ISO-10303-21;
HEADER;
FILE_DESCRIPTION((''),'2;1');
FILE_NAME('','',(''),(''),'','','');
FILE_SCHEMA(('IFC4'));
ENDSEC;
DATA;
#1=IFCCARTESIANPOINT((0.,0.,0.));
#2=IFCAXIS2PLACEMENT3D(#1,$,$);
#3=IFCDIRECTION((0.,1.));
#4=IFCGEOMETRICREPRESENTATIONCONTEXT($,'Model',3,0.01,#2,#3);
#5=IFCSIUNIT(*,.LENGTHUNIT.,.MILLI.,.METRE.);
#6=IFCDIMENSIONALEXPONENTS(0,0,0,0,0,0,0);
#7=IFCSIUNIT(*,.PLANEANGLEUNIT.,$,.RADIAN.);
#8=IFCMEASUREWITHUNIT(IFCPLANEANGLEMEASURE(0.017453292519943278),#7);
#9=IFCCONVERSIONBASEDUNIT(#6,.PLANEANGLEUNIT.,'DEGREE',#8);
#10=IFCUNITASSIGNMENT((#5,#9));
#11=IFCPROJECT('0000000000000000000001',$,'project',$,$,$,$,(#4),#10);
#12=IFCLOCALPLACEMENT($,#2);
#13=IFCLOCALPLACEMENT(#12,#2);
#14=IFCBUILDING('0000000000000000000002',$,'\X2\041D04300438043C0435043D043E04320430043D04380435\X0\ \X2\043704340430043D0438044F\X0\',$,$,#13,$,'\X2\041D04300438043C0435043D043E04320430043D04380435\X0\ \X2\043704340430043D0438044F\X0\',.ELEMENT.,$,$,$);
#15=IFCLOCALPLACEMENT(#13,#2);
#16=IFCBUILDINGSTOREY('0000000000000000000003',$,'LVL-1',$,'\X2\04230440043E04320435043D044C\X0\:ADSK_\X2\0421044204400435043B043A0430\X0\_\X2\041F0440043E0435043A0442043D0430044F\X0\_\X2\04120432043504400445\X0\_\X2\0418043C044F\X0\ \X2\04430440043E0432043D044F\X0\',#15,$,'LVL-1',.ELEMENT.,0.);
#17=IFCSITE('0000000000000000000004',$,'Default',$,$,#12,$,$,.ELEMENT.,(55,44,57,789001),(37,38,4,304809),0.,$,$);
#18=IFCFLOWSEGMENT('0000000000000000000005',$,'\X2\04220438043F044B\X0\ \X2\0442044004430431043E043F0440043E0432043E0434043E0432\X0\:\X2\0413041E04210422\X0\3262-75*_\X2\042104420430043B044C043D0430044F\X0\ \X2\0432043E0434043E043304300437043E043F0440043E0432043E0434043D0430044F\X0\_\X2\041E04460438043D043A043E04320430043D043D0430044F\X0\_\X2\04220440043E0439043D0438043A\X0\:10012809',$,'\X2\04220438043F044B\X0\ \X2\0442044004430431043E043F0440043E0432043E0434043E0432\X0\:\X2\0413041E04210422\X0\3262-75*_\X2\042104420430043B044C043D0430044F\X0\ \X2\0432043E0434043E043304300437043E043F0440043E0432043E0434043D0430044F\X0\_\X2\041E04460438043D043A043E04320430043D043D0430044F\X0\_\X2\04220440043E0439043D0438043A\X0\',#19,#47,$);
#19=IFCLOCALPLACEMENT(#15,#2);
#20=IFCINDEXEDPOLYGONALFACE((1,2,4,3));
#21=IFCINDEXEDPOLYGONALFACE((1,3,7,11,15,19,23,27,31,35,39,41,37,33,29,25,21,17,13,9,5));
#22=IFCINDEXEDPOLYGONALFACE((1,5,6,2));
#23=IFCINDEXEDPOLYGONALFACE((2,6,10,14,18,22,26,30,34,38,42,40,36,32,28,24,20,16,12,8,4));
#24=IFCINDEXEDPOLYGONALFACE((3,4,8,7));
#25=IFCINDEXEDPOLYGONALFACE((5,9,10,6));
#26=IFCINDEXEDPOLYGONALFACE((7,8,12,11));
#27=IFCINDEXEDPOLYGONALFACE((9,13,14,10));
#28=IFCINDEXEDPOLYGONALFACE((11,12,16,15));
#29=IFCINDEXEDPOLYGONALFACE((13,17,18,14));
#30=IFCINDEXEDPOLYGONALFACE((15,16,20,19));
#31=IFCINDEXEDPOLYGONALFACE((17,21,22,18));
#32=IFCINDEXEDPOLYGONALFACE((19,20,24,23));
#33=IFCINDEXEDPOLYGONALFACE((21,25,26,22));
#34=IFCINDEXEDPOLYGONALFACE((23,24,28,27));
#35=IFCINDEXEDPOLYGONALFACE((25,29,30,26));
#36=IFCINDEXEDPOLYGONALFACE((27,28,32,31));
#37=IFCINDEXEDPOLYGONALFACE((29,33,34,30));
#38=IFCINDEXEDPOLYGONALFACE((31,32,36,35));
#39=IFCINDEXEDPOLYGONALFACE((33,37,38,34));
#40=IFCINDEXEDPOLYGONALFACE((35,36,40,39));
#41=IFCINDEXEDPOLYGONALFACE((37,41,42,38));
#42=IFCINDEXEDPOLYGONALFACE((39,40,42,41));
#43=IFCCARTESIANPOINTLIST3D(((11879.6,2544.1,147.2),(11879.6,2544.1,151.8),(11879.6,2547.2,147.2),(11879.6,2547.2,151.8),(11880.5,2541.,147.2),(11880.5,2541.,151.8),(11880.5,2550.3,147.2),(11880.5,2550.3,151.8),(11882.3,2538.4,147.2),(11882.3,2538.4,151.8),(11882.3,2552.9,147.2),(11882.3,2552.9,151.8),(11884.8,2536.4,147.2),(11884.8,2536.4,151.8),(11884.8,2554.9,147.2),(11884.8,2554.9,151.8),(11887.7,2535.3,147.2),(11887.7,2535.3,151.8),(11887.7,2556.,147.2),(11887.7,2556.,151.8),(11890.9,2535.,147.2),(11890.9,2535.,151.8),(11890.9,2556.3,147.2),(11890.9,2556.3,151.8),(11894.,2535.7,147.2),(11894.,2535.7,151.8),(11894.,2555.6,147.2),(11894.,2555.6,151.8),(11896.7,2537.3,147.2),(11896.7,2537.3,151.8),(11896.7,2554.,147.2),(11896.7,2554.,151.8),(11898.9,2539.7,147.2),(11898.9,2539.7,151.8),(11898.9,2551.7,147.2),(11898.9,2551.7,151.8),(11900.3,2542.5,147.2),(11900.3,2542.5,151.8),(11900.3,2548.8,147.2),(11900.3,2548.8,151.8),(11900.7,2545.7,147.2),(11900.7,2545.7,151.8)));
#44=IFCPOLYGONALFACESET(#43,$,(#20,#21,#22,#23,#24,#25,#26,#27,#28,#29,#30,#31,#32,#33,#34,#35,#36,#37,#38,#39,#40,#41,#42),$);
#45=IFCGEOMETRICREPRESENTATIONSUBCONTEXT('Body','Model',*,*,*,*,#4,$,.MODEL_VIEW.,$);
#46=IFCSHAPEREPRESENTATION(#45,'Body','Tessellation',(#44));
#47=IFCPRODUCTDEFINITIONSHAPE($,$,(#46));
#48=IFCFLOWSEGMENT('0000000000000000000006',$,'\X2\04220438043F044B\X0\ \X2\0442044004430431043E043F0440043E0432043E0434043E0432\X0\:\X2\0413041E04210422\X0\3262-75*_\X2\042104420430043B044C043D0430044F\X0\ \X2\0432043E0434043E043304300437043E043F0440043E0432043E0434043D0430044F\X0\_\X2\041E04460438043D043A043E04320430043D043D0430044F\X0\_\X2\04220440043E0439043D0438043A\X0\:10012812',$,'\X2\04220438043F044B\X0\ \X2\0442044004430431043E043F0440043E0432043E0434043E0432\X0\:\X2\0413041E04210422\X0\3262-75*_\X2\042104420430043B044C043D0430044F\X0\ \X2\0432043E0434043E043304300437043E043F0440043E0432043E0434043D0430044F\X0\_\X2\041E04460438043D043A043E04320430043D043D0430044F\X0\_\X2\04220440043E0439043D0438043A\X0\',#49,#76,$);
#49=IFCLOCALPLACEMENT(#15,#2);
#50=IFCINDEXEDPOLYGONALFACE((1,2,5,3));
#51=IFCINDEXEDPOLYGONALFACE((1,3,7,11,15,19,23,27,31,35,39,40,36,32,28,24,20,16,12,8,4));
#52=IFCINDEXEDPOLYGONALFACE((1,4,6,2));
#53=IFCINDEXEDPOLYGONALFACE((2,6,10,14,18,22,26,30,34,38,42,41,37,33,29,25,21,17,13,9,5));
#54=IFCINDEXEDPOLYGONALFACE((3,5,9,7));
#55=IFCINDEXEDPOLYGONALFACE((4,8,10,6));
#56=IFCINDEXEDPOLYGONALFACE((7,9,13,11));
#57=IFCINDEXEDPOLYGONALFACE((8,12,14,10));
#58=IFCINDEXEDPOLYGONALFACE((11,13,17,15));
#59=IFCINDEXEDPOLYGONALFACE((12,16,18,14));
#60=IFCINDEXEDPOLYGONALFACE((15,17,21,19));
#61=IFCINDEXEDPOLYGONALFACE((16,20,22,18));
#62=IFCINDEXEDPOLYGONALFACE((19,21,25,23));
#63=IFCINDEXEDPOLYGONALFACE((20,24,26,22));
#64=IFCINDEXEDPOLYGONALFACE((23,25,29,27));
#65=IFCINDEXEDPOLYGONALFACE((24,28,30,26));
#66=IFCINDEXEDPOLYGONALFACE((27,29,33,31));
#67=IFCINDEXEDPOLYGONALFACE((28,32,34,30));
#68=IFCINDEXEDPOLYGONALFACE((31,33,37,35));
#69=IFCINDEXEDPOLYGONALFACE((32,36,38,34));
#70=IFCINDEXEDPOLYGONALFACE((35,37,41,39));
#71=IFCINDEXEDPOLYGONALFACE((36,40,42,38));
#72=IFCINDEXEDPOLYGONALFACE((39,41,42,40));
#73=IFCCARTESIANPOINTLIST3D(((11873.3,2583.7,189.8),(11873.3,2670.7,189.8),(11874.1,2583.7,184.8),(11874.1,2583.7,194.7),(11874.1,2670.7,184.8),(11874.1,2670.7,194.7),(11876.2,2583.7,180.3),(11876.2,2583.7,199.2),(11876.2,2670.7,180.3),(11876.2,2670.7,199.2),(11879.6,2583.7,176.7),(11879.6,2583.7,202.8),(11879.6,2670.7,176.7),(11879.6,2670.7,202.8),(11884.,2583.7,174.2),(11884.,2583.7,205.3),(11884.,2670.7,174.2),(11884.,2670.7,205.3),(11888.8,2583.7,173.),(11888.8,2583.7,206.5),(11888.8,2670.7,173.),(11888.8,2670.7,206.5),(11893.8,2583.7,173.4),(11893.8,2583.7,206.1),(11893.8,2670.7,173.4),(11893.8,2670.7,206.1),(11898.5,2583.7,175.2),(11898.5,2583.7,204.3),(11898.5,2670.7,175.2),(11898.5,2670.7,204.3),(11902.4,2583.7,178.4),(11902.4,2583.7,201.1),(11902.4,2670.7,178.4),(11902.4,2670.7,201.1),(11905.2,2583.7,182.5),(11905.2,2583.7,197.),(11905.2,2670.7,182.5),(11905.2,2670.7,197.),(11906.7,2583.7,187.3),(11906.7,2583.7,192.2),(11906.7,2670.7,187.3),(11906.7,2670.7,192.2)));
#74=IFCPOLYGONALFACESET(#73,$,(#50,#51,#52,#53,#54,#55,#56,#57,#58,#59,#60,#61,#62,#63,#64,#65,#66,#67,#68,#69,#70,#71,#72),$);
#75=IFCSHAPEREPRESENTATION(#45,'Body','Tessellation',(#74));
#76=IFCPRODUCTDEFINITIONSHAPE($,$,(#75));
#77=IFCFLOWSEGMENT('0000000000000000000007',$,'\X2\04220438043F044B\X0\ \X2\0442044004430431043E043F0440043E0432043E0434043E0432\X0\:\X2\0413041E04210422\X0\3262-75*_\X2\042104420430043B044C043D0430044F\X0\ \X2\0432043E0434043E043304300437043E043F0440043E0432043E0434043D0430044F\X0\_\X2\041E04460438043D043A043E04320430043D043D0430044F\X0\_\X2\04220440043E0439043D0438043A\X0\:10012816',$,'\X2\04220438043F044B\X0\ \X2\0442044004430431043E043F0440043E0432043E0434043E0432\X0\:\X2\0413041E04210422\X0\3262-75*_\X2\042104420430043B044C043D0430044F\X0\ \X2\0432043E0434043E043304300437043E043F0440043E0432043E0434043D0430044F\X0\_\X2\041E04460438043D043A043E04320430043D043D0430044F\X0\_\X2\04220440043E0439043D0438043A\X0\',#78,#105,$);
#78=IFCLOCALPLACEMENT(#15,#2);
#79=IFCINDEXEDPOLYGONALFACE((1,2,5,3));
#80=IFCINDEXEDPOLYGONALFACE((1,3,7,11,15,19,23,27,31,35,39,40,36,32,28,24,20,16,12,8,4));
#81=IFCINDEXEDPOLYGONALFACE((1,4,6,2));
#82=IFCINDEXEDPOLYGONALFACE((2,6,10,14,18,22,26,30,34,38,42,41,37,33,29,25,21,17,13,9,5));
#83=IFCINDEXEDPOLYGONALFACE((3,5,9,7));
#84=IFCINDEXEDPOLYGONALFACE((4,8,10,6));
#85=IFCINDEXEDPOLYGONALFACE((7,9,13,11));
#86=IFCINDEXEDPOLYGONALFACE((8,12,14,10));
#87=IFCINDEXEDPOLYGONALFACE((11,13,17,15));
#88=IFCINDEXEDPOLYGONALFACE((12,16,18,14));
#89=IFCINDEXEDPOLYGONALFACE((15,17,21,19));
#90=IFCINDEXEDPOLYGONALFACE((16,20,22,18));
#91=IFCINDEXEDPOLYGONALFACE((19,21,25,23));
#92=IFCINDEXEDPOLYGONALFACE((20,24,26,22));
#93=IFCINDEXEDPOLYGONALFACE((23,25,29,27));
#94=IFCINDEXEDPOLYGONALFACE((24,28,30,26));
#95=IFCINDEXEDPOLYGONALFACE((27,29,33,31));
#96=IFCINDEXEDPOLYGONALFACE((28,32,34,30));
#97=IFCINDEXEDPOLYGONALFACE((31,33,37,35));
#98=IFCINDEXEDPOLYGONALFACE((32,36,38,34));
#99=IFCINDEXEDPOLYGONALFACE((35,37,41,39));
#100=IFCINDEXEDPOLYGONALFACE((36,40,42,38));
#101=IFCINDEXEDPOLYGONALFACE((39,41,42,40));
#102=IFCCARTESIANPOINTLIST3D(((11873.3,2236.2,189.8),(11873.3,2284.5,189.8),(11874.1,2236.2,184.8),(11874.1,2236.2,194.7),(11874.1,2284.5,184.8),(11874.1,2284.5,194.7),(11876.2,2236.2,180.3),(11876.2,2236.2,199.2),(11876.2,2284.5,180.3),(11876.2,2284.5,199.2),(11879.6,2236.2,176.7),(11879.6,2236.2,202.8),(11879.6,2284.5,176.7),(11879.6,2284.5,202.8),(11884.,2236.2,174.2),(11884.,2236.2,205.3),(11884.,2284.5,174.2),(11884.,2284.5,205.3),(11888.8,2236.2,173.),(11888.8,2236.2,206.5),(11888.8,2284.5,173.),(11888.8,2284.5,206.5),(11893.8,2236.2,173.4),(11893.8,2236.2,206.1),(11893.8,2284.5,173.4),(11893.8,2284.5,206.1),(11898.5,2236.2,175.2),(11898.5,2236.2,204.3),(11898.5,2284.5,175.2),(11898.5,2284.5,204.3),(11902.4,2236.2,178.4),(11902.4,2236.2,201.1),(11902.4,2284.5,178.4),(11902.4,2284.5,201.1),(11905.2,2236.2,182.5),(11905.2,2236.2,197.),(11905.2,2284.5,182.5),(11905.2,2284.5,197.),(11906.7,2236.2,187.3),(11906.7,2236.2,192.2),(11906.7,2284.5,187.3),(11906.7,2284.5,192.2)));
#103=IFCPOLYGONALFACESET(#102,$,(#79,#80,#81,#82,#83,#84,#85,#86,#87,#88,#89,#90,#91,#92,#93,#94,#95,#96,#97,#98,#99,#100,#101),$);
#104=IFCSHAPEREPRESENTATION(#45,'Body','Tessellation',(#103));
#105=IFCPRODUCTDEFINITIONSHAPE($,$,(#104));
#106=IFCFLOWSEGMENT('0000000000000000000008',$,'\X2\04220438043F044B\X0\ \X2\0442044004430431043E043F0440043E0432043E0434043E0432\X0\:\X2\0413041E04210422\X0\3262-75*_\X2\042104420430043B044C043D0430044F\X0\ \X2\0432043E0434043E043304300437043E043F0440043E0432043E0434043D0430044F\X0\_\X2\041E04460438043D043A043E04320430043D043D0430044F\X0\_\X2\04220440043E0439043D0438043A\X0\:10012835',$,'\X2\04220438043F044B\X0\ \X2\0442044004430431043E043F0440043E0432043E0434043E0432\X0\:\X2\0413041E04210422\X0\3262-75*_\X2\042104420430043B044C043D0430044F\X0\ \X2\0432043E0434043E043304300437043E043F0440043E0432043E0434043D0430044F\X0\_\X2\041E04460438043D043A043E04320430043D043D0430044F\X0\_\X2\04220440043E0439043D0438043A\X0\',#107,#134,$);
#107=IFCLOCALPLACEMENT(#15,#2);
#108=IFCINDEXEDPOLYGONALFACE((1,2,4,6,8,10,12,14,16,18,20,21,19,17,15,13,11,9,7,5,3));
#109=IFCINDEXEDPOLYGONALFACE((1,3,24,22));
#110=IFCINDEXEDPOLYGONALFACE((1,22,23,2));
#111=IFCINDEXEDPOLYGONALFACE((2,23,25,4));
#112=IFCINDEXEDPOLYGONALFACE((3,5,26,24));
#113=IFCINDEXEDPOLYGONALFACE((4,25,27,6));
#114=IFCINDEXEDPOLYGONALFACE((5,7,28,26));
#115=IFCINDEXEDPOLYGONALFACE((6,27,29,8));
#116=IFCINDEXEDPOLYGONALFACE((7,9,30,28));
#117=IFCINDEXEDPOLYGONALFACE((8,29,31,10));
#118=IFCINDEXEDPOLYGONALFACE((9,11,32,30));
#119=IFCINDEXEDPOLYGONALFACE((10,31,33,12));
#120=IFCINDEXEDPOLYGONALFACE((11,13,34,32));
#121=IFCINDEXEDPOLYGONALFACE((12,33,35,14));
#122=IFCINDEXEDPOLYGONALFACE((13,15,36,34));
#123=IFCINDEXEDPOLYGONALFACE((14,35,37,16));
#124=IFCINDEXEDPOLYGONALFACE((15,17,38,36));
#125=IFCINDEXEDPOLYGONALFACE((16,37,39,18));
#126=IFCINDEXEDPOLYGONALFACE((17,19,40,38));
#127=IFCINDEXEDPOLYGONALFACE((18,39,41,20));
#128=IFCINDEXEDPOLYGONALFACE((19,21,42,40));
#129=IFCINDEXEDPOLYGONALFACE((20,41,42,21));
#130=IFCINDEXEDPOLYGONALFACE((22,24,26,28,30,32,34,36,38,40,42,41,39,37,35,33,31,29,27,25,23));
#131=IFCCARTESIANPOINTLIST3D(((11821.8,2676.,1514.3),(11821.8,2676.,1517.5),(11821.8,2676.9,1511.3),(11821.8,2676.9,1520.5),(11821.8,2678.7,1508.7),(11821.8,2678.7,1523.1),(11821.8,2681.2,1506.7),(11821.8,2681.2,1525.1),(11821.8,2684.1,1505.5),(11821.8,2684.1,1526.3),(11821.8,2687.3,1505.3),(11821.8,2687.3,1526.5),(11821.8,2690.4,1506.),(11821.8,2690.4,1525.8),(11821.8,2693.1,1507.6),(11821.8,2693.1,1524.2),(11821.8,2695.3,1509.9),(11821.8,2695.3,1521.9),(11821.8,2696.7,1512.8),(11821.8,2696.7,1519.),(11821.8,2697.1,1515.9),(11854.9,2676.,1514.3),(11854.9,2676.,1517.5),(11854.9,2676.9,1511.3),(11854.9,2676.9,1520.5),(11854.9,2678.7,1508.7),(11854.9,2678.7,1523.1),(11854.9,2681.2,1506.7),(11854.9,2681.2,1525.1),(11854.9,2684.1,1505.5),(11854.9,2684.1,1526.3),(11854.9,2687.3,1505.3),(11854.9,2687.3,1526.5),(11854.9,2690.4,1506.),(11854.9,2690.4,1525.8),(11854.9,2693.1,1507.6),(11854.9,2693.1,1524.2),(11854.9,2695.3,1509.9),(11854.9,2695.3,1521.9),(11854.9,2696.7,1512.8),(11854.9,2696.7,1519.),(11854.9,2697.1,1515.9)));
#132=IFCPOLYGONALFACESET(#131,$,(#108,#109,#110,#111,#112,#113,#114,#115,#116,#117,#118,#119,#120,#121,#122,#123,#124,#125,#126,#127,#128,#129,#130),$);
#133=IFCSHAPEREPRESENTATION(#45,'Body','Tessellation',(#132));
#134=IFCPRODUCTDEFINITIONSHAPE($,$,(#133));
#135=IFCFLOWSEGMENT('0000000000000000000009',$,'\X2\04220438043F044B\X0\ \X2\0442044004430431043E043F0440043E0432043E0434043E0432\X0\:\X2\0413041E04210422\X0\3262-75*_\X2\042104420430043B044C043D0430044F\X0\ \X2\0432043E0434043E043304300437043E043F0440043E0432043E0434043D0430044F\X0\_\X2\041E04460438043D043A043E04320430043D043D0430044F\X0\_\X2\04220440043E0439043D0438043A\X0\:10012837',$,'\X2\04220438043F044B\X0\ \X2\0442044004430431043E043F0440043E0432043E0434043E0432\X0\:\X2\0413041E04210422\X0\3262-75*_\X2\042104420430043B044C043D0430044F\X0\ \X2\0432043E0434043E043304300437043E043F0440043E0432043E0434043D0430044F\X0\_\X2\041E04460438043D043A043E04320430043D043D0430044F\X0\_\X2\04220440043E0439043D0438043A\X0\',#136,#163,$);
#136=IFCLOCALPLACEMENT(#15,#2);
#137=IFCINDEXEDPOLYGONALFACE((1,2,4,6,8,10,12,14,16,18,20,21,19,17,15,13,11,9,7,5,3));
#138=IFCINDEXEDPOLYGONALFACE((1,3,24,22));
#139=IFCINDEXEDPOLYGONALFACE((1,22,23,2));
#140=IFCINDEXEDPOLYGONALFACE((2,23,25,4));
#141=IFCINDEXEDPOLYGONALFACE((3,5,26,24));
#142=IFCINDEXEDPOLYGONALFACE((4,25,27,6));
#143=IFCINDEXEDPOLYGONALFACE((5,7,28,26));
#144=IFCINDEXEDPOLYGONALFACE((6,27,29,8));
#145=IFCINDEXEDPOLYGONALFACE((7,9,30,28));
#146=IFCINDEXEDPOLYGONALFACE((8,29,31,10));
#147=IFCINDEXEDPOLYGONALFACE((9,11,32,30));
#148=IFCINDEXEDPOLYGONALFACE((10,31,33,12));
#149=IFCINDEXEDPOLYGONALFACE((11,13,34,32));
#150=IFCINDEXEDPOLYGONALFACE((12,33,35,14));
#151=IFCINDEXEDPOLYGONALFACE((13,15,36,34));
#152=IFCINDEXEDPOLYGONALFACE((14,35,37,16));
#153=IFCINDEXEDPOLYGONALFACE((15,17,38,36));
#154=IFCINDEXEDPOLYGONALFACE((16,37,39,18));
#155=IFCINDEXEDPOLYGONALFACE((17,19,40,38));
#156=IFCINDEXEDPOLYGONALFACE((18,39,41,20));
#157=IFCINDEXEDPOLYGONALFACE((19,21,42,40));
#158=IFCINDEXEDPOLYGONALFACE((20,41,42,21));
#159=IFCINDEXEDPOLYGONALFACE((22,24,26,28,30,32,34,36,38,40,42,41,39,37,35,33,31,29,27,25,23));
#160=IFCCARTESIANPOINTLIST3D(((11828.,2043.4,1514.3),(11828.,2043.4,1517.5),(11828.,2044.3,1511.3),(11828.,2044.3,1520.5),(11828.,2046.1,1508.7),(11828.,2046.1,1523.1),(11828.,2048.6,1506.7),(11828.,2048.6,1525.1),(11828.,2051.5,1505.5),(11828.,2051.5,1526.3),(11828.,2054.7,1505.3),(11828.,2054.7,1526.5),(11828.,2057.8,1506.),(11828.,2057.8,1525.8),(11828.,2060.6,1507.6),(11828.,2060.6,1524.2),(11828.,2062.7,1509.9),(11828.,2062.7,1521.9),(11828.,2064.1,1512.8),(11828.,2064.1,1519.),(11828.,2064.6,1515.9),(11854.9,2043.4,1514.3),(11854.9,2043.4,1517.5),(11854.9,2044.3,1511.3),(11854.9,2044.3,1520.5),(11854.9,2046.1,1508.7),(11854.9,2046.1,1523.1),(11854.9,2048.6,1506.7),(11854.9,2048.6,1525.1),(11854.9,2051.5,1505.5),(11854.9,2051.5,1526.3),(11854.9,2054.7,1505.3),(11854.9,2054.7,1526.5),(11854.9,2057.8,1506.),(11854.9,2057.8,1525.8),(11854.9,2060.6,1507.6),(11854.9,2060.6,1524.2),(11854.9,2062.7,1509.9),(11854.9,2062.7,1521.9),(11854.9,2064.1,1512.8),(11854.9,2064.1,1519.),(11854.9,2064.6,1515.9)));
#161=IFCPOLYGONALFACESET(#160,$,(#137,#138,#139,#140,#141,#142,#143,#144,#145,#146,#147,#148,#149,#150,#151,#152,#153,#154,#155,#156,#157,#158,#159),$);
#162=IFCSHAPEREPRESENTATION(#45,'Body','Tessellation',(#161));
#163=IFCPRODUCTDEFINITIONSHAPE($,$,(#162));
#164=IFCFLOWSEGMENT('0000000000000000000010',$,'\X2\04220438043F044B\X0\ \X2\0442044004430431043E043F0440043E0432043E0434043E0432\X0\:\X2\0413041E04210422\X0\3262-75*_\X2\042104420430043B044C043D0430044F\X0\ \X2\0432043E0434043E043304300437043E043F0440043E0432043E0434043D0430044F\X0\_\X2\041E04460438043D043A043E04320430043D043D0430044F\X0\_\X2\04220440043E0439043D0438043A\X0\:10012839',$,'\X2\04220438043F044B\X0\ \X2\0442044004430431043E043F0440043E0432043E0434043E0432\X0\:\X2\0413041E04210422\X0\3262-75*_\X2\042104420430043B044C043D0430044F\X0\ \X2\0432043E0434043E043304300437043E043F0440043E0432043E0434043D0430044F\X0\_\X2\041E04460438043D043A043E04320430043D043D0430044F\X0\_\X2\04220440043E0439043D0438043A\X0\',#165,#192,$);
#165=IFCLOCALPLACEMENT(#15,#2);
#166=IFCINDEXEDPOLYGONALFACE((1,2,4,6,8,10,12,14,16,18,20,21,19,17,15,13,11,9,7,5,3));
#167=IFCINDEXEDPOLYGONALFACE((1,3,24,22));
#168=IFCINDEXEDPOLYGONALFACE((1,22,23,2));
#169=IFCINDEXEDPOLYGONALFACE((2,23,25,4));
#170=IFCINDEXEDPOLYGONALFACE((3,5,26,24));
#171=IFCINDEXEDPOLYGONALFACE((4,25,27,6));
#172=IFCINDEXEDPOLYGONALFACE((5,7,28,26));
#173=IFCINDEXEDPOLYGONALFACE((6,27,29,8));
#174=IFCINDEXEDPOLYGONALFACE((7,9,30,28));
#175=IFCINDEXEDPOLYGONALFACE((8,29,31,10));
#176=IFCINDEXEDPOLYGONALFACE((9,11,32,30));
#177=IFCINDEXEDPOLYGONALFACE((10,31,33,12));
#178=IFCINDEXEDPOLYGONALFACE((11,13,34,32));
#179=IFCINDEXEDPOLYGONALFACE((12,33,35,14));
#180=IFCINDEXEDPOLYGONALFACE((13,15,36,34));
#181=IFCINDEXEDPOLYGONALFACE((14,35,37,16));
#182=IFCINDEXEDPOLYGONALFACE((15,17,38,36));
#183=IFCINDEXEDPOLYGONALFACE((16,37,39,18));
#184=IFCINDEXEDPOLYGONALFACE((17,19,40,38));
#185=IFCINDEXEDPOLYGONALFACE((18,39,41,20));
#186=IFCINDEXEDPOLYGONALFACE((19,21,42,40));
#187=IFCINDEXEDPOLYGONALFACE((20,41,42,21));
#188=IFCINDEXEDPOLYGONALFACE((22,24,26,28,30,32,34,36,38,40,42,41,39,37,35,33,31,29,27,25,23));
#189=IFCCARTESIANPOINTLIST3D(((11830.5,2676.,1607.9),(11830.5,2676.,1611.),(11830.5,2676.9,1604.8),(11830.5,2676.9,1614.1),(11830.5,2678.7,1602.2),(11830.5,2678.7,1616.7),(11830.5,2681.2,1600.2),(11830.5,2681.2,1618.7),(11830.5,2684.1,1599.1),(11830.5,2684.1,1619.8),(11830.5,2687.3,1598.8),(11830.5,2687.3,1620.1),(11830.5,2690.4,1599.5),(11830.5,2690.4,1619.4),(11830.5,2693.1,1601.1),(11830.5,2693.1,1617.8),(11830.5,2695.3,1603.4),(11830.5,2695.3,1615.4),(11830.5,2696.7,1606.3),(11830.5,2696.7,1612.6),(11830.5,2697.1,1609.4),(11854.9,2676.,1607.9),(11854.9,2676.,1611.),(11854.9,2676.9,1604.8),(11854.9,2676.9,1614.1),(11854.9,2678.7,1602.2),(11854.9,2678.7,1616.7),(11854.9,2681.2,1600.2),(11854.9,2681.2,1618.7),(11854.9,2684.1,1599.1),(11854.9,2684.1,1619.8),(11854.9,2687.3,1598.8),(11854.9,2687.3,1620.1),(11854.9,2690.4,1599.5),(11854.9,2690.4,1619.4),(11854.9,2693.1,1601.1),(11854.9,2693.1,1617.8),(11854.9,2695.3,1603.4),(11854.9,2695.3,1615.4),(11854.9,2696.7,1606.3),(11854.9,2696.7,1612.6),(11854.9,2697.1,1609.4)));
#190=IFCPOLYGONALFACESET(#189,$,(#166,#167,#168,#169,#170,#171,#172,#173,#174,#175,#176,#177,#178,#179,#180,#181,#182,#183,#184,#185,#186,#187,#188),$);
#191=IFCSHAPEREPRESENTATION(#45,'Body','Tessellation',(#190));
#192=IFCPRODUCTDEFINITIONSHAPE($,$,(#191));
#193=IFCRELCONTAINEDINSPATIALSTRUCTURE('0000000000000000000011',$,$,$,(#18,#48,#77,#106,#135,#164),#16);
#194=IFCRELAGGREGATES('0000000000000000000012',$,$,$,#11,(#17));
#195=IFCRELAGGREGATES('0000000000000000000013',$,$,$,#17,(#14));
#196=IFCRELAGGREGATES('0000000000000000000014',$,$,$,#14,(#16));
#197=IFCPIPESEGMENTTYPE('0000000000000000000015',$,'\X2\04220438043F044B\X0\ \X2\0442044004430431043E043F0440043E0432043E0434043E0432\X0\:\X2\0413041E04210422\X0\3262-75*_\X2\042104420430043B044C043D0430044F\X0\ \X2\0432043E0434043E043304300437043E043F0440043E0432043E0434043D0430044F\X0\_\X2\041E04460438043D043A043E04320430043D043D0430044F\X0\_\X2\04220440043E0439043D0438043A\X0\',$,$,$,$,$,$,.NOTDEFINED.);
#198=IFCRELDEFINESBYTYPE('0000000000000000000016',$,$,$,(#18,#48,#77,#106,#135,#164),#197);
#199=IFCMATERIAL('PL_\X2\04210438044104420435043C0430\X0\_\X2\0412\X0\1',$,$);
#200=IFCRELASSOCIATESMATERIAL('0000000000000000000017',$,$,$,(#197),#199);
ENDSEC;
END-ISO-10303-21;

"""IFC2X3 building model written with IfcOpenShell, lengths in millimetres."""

from ifc_helpers import new_model, entity, si_unit, converted_unit, direction, frame, frame_2d, origin, origin_2d_with_axis, place, context, subcontext, project, spatial, circle, extrude, material, type_object, element, save


model = new_model("IFC2X3")

# Units and contexts
model_context = context("Model", 3, precision=0.01, world=origin(), true_north=direction((0.0, 1.0)))
body_context = subcontext(model_context, "Body", "Model", "MODEL_VIEW")
ifc_project = project(units=[si_unit("LENGTHUNIT", "METRE", prefix="MILLI"), converted_unit("PLANEANGLEUNIT", "DEGREE", entity("IfcPlaneAngleMeasure", 0.017453292519943278), si_unit("PLANEANGLEUNIT", "RADIAN"), dimensions=[0, 0, 0, 0, 0, 0, 0])], contexts=[model_context])

# Site, building, storey
site_placement = place(None, origin())
site = spatial("IfcSite", under=ifc_project, at=site_placement, Name="Default", CompositionType="ELEMENT", RefLatitude=(55, 44, 57, 789001), RefLongitude=(37, 38, 4, 304809), RefElevation=0.0)
building_placement = place(site_placement, origin())
building = spatial("IfcBuilding", under=site, at=building_placement, Name="Наименование здания", LongName="Наименование здания", CompositionType="ELEMENT")
storey_placement = place(building_placement, origin())
storey = spatial("IfcBuildingStorey", under=building, at=storey_placement, Name="LVL-1", ObjectType="Уровень:ADSK_Стрелка_Проектная_Вверх_Имя уровня", LongName="LVL-1", CompositionType="ELEMENT", Elevation=0.0)

# Flow segments
ifc_material_1 = material(Name="PL_Система_В1")
pipe_segment_type_1 = type_object("IfcPipeSegmentType", Name="Типы трубопроводов:ГОСТ3262-75*_Стальная водогазопроводная_Оцинкованная_Тройник", PredefinedType="NOTDEFINED", material=ifc_material_1)
flow_segment_1_placement = place(storey_placement, origin())
element("IfcFlowSegment", 1, at=flow_segment_1_placement, inside=storey, type_object=pipe_segment_type_1, Name="Типы трубопроводов:ГОСТ3262-75*_Стальная водогазопроводная_Оцинкованная_Тройник:10012809", ObjectType="Типы трубопроводов:ГОСТ3262-75*_Стальная водогазопроводная_Оцинкованная_Тройник", context=body_context, shape_type="SweptSolid", body=[
    extrude(circle(Radius=10.7, at=origin_2d_with_axis()), frame((11890.1, 2545.7, 147.2)), (0.0, 0.0, 1.0), 4.5),
])
flow_segment_2_placement = place(storey_placement, origin())
element("IfcFlowSegment", 2, at=flow_segment_2_placement, inside=storey, type_object=pipe_segment_type_1, Name="Типы трубопроводов:ГОСТ3262-75*_Стальная водогазопроводная_Оцинкованная_Тройник:10012812", ObjectType="Типы трубопроводов:ГОСТ3262-75*_Стальная водогазопроводная_Оцинкованная_Тройник", context=body_context, shape_type="SweptSolid", body=[
    extrude(circle(Radius=16.8, at=frame_2d((0.0, 0.0), x_axis=(1.0, 0.0))), frame((11890.1, 2583.7, 189.8), z_axis=(0.0, 1.0, 0.0), x_axis=(-1.0, 0.0, 0.0)), (0.0, 0.0, 1.0), 87.1),
])
flow_segment_3_placement = place(storey_placement, origin())
element("IfcFlowSegment", 3, at=flow_segment_3_placement, inside=storey, type_object=pipe_segment_type_1, Name="Типы трубопроводов:ГОСТ3262-75*_Стальная водогазопроводная_Оцинкованная_Тройник:10012816", ObjectType="Типы трубопроводов:ГОСТ3262-75*_Стальная водогазопроводная_Оцинкованная_Тройник", context=body_context, shape_type="SweptSolid", body=[
    extrude(circle(Radius=16.8, at=frame_2d((0.0, 0.0), x_axis=(1.0, 0.0))), frame((11890.1, 2236.2, 189.8), z_axis=(0.0, 1.0, 0.0), x_axis=(-1.0, 0.0, 0.0)), (0.0, 0.0, 1.0), 48.3),
])
flow_segment_4_placement = place(storey_placement, origin())
element("IfcFlowSegment", 4, at=flow_segment_4_placement, inside=storey, type_object=pipe_segment_type_1, Name="Типы трубопроводов:ГОСТ3262-75*_Стальная водогазопроводная_Оцинкованная_Тройник:10012835", ObjectType="Типы трубопроводов:ГОСТ3262-75*_Стальная водогазопроводная_Оцинкованная_Тройник", context=body_context, shape_type="SweptSolid", body=[
    extrude(circle(Radius=10.7, at=frame_2d((0.0, 0.0), x_axis=(1.0, 0.0))), frame((11821.8, 2686.5, 1515.9), z_axis=(1.0, 0.0, 0.0), x_axis=(0.0, 1.0, 0.0)), (0.0, 0.0, 1.0), 33.1),
])
flow_segment_5_placement = place(storey_placement, origin())
element("IfcFlowSegment", 5, at=flow_segment_5_placement, inside=storey, type_object=pipe_segment_type_1, Name="Типы трубопроводов:ГОСТ3262-75*_Стальная водогазопроводная_Оцинкованная_Тройник:10012837", ObjectType="Типы трубопроводов:ГОСТ3262-75*_Стальная водогазопроводная_Оцинкованная_Тройник", context=body_context, shape_type="SweptSolid", body=[
    extrude(circle(Radius=10.7, at=frame_2d((0.0, 0.0), x_axis=(1.0, 0.0))), frame((11828.0, 2053.9, 1515.9), z_axis=(1.0, 0.0, 0.0), x_axis=(0.0, 1.0, 0.0)), (0.0, 0.0, 1.0), 26.9),
])
flow_segment_6_placement = place(storey_placement, origin())
element("IfcFlowSegment", 6, at=flow_segment_6_placement, inside=storey, type_object=pipe_segment_type_1, Name="Типы трубопроводов:ГОСТ3262-75*_Стальная водогазопроводная_Оцинкованная_Тройник:10012839", ObjectType="Типы трубопроводов:ГОСТ3262-75*_Стальная водогазопроводная_Оцинкованная_Тройник", context=body_context, shape_type="SweptSolid", body=[
    extrude(circle(Radius=10.7, at=origin_2d_with_axis()), frame((11830.5, 2686.5, 1609.4), z_axis=(1.0, 0.0, 0.0), x_axis=(0.0, 1.0, 0.0)), (0.0, 0.0, 1.0), 24.4),
])

save(model, "model.ifc")
